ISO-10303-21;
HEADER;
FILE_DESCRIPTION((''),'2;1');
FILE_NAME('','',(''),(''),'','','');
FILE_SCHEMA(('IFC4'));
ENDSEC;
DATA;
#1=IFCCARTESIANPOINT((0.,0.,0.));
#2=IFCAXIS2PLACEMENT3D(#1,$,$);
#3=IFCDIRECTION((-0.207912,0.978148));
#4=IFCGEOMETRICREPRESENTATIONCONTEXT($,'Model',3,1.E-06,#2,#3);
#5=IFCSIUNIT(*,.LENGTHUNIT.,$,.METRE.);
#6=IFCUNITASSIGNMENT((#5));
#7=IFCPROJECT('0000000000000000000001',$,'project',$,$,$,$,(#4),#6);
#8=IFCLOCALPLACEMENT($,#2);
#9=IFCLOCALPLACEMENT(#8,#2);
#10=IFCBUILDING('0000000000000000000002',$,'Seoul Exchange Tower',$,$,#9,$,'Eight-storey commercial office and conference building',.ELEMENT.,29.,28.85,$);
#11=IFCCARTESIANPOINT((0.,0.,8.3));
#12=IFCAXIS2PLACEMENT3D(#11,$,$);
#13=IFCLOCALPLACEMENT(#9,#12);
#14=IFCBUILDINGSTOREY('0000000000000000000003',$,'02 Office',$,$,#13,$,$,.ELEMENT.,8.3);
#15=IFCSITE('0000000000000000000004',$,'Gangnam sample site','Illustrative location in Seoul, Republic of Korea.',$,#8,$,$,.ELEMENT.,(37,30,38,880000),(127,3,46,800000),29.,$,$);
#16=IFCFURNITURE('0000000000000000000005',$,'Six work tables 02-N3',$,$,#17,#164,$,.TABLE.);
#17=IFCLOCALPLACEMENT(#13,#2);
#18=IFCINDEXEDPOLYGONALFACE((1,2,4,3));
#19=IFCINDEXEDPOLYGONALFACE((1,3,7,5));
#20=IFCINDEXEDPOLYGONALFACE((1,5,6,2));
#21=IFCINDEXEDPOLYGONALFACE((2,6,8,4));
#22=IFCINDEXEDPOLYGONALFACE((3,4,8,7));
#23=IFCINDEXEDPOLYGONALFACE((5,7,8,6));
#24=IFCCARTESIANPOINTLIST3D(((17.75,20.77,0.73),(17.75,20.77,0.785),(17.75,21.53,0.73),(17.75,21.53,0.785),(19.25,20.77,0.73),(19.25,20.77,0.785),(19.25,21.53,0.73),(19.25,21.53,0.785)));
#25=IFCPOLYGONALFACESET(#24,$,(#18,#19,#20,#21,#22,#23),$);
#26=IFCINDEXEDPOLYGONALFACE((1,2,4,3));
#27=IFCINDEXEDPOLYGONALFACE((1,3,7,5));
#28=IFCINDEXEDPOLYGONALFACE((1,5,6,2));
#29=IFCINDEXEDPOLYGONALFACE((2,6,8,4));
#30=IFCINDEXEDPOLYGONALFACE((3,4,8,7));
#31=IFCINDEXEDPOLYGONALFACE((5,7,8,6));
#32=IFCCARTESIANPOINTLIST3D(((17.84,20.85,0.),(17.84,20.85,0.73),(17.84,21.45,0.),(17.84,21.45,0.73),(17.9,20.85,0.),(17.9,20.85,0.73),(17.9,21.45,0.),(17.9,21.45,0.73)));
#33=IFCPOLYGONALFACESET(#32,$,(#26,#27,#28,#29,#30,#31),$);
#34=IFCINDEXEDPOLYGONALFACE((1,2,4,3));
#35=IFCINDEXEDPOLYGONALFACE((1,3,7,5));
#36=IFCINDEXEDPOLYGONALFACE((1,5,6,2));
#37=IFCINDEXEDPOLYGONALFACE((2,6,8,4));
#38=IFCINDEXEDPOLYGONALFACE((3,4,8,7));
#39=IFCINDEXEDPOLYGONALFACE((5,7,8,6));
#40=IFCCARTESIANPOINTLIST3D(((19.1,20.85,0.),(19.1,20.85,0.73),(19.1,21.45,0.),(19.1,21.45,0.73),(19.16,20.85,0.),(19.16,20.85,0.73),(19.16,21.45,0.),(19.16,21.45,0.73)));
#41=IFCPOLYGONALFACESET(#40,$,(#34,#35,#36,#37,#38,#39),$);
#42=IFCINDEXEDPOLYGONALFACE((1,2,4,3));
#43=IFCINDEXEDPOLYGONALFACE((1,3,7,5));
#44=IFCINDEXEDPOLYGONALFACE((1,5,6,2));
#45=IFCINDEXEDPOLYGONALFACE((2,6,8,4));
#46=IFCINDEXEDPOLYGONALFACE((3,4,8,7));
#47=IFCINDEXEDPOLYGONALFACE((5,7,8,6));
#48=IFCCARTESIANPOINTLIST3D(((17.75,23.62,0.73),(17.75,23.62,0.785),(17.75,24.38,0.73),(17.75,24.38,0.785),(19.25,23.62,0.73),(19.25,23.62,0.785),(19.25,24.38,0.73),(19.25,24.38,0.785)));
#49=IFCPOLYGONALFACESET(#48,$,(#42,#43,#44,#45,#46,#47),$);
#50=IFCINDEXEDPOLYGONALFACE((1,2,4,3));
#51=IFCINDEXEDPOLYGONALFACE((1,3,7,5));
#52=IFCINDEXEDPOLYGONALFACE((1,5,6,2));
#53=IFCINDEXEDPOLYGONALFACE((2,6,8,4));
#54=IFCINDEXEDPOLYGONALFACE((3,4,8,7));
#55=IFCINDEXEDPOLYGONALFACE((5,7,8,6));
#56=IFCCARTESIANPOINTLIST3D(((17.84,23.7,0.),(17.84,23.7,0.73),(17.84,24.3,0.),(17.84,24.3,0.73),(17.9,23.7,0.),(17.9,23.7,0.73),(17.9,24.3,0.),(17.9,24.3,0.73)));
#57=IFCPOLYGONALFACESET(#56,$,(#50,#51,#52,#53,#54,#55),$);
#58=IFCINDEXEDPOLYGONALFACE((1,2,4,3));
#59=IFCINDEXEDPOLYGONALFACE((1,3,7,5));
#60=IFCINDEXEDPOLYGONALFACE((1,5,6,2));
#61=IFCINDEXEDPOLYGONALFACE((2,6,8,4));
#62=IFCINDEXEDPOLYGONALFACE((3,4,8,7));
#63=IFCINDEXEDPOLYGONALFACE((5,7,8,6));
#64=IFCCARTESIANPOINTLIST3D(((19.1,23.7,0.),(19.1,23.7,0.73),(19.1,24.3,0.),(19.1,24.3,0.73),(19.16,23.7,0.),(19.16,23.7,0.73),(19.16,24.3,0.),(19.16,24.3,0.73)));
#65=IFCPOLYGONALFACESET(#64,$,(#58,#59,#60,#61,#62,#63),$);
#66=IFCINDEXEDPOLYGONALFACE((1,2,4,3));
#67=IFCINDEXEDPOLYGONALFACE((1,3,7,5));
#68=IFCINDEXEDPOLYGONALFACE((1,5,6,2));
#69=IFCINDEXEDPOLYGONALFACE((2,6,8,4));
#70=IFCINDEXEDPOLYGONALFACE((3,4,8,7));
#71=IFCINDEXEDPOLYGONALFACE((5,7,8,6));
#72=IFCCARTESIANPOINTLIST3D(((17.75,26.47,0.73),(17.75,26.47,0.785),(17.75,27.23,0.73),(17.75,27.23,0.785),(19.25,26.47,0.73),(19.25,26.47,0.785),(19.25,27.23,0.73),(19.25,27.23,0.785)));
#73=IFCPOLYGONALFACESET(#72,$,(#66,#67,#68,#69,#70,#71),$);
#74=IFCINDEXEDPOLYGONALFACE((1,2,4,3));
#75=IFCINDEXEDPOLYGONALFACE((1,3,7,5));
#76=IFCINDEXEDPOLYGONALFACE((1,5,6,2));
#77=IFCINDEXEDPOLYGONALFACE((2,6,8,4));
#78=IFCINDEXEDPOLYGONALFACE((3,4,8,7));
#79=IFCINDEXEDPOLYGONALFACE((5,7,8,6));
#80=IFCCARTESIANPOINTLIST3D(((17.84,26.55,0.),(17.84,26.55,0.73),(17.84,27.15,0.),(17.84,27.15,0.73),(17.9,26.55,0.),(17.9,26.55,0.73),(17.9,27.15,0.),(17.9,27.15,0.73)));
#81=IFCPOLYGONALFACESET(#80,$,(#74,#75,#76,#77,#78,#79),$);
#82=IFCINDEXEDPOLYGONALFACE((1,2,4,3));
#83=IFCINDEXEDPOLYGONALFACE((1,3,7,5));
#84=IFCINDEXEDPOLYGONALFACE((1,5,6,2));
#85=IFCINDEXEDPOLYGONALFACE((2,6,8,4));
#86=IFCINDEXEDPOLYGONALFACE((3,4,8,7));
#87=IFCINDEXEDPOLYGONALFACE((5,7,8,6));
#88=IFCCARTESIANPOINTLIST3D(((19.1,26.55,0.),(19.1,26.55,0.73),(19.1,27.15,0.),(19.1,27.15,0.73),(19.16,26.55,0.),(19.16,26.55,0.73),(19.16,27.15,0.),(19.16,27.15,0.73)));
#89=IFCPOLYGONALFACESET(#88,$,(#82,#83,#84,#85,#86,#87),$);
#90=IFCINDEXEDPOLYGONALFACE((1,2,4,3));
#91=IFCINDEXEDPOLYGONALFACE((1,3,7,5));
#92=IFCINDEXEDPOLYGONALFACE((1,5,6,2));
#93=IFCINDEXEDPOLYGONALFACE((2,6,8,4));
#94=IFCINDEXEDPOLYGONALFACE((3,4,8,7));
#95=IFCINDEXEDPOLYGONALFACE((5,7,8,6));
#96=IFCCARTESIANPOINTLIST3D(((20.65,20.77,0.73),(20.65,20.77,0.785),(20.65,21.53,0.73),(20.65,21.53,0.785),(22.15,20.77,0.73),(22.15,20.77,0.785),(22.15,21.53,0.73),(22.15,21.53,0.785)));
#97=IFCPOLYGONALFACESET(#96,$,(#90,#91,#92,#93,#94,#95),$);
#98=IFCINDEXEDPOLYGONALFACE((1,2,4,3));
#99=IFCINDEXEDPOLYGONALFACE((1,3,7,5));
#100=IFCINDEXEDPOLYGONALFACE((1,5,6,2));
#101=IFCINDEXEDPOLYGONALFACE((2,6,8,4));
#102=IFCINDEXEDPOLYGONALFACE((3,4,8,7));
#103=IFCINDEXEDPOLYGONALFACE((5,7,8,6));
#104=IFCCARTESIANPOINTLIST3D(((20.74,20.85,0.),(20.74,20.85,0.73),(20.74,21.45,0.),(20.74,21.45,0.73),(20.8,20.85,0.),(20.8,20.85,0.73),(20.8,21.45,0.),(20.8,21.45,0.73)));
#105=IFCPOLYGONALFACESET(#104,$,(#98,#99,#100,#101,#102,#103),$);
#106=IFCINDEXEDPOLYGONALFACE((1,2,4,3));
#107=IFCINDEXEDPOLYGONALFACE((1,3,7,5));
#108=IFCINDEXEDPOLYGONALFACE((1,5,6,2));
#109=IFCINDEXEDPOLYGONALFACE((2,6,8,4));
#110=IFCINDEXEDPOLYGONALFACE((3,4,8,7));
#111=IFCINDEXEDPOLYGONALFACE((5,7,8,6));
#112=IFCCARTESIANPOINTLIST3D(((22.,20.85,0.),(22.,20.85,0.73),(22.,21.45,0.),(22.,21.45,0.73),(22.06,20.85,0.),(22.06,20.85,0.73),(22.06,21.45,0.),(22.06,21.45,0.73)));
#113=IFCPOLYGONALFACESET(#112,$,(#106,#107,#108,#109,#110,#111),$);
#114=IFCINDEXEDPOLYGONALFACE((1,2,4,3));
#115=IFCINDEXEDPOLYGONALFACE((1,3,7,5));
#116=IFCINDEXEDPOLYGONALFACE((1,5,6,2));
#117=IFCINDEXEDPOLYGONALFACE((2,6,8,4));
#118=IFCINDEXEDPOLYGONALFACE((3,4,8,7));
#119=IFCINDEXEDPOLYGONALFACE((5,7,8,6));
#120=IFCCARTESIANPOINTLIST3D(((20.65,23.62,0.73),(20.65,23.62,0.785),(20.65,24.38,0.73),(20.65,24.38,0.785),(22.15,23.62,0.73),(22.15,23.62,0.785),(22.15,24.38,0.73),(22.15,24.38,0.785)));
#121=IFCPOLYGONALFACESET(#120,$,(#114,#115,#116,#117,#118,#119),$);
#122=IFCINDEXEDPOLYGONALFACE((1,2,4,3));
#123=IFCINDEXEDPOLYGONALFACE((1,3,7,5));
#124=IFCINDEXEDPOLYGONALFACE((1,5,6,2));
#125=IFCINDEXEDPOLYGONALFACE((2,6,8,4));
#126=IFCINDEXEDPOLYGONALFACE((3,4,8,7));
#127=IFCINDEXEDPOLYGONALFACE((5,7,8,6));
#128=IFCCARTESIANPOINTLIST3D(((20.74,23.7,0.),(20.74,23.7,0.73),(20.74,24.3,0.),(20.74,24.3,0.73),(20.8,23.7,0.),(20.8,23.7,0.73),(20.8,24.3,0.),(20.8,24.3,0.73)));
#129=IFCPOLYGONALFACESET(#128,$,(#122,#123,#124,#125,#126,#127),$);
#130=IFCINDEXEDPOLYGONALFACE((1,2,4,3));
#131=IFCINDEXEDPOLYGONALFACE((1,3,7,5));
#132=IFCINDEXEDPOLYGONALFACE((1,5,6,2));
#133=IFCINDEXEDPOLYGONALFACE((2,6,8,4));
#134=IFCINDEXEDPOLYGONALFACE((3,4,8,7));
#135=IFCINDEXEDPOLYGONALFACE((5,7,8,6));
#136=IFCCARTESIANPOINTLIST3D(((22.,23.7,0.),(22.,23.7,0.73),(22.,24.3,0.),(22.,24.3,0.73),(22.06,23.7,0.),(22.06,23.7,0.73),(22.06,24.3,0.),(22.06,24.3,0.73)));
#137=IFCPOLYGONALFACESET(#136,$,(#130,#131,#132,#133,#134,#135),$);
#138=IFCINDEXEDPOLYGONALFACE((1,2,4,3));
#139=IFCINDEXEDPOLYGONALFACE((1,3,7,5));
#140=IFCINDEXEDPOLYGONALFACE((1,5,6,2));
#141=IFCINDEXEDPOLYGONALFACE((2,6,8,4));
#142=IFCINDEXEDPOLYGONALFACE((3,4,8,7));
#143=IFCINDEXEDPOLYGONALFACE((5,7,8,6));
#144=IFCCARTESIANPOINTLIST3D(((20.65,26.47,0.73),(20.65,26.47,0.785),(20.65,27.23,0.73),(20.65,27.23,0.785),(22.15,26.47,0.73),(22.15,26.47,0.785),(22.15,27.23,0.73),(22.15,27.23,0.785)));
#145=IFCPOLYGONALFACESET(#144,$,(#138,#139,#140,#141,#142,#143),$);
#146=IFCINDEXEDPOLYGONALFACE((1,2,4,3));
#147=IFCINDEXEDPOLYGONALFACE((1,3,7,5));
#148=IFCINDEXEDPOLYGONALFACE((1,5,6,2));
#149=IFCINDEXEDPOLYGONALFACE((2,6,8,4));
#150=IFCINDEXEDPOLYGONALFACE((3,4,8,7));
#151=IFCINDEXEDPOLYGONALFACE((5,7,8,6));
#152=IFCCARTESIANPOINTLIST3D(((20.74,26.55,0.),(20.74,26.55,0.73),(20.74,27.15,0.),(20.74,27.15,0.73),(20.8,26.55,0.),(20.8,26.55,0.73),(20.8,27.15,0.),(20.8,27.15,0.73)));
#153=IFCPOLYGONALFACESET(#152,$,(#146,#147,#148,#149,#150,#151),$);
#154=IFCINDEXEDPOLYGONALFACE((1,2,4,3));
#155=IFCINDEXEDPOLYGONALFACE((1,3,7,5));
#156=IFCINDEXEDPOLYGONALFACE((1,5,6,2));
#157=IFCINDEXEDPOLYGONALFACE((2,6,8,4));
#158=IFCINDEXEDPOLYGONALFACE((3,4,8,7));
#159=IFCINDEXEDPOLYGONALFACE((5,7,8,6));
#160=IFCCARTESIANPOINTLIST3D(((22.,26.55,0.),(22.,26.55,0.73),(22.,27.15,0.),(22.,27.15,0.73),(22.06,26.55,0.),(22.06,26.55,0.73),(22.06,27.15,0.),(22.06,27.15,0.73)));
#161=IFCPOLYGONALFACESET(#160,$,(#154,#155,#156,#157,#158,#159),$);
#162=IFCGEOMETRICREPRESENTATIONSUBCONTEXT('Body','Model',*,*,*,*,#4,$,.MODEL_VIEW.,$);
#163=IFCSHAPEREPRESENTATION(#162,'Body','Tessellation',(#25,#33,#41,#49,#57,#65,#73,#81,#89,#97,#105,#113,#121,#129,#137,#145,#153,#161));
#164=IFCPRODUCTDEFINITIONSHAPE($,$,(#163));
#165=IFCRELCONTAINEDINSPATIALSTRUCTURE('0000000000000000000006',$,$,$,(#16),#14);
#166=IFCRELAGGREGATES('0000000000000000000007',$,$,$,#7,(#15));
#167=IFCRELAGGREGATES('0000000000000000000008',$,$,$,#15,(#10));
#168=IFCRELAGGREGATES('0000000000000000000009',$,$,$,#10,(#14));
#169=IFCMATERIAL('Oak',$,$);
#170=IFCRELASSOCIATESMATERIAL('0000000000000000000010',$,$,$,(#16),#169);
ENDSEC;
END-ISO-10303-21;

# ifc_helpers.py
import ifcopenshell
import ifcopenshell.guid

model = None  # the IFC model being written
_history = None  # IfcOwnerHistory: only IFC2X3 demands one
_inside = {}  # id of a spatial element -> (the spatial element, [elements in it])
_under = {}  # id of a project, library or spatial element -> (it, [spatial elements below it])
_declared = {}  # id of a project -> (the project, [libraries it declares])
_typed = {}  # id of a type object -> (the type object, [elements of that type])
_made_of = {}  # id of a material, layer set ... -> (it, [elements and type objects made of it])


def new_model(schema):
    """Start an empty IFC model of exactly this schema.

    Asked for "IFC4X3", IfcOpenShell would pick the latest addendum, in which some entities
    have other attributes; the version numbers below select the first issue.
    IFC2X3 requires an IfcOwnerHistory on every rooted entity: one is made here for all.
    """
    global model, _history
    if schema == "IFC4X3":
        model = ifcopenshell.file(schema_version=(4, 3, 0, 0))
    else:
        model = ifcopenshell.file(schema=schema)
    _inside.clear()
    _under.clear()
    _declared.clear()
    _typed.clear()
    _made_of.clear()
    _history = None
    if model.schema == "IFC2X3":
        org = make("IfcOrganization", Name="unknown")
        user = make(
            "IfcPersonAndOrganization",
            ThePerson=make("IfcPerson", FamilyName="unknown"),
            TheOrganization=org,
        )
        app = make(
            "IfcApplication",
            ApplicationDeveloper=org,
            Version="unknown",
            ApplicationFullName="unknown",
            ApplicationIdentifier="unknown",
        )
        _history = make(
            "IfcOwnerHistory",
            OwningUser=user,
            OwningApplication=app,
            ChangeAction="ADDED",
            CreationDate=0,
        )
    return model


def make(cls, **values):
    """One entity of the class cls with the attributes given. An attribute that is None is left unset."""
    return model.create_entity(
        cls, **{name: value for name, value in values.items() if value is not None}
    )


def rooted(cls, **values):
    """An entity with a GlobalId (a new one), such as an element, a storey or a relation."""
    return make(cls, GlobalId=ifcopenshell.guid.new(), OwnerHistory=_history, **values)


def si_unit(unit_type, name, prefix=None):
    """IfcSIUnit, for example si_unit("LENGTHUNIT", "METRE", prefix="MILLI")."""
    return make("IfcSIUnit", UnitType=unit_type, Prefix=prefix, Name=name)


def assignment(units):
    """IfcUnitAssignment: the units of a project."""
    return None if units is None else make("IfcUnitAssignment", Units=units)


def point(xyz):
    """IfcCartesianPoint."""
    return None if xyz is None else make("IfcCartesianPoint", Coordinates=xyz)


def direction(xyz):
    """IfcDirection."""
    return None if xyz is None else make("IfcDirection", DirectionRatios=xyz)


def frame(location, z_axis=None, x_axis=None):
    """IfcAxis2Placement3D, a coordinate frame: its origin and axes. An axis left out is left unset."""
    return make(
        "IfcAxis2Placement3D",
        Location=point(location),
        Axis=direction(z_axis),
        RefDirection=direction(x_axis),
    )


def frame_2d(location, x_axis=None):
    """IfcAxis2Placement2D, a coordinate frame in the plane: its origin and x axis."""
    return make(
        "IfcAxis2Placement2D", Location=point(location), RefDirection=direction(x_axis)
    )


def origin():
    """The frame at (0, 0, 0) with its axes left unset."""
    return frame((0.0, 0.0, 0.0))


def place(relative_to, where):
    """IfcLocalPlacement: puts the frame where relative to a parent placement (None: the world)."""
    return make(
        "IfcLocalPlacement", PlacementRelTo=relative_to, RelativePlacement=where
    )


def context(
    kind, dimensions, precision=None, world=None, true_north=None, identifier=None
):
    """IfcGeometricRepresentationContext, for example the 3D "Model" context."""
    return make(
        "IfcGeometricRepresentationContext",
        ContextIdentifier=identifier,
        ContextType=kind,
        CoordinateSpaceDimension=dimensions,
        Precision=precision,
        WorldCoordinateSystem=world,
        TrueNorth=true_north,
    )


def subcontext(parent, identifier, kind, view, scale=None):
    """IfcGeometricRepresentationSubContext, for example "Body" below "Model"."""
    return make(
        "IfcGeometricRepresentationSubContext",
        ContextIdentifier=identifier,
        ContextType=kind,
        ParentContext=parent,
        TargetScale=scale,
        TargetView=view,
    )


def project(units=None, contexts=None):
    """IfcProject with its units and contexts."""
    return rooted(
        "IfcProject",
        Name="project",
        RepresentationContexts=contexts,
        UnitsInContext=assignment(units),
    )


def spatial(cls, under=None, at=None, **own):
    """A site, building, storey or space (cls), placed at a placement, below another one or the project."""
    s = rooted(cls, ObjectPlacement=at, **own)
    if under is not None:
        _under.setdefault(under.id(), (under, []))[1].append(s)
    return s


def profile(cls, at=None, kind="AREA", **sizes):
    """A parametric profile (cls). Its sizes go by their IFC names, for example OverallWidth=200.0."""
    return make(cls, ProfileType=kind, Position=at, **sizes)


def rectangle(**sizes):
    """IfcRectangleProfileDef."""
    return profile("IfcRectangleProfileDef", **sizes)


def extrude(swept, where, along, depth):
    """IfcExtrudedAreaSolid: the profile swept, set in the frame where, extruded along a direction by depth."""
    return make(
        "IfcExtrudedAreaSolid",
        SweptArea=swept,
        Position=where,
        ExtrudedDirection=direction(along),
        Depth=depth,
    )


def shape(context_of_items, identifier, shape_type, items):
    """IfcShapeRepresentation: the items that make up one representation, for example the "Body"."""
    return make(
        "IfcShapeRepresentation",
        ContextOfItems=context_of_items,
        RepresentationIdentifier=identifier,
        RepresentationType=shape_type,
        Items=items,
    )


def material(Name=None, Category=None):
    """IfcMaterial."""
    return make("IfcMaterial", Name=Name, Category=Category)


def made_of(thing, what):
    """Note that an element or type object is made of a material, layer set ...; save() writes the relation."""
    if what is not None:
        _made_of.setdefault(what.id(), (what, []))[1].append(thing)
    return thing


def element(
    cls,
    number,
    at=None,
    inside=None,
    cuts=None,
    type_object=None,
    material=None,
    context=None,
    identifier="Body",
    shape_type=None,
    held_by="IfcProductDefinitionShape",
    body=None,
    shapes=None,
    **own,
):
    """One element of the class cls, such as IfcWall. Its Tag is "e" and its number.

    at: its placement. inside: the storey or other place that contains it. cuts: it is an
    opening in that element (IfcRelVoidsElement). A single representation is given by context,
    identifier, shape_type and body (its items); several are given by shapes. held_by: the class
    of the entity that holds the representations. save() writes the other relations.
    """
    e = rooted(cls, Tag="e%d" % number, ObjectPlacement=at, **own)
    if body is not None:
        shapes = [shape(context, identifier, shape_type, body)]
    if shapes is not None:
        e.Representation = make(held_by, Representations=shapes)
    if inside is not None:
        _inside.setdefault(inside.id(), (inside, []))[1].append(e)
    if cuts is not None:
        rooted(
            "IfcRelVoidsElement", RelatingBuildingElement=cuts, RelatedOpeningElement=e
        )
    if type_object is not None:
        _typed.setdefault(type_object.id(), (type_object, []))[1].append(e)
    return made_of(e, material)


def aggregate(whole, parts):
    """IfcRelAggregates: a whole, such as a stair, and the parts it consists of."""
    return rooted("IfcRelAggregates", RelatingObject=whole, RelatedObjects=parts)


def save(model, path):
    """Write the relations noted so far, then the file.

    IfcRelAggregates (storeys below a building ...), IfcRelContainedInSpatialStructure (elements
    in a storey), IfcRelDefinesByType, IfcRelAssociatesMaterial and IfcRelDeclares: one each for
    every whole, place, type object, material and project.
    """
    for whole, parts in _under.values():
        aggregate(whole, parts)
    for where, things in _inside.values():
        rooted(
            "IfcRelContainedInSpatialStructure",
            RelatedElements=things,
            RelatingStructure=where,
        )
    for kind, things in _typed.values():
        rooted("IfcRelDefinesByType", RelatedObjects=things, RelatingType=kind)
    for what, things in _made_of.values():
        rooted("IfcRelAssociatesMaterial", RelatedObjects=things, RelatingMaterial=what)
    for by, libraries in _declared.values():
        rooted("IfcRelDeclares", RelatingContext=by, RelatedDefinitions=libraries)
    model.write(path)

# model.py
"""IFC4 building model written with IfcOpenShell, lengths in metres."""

from ifc_helpers import new_model, si_unit, direction, frame, frame_2d, origin, place, context, subcontext, project, spatial, rectangle, extrude, material, element, save


model = new_model("IFC4")

# Units and contexts
model_context = context("Model", 3, precision=1e-06, world=origin(), true_north=direction((-0.207912, 0.978148)))
body_context = subcontext(model_context, "Body", "Model", "MODEL_VIEW")
ifc_project = project(units=[si_unit("LENGTHUNIT", "METRE")], contexts=[model_context])

# Site, building, storey
site_placement = place(None, origin())
site = spatial("IfcSite", under=ifc_project, at=site_placement, Name="Gangnam sample site", Description="Illustrative location in Seoul, Republic of Korea.", CompositionType="ELEMENT", RefLatitude=(37, 30, 38, 880000), RefLongitude=(127, 3, 46, 800000), RefElevation=29.0)
building_placement = place(site_placement, origin())
building = spatial("IfcBuilding", under=site, at=building_placement, Name="Seoul Exchange Tower", LongName="Eight-storey commercial office and conference building", CompositionType="ELEMENT", ElevationOfRefHeight=29.0, ElevationOfTerrain=28.85)
storey_placement = place(building_placement, frame((0.0, 0.0, 8.3)))
storey = spatial("IfcBuildingStorey", under=building, at=storey_placement, Name="02 Office", CompositionType="ELEMENT", Elevation=8.3)

# Shared definitions
placement_1 = place(storey_placement, origin())

# Furniture
ifc_material_1 = material(Name="Oak")
element("IfcFurniture", 1, at=placement_1, inside=storey, material=ifc_material_1, Name="Six work tables 02-N3", PredefinedType="TABLE", context=body_context, shape_type="SweptSolid", body=[
    extrude(rectangle(XDim=1.5, YDim=0.76, at=frame_2d((0.75, 0.38))), frame((17.75, 20.77, 0.73)), (0.0, 0.0, 1.0), 0.055),
    extrude(rectangle(XDim=0.06, YDim=0.6, at=frame_2d((0.03, 0.3))), frame((17.84, 20.85, 0.0)), (0.0, 0.0, 1.0), 0.73),
    extrude(rectangle(XDim=0.06, YDim=0.6, at=frame_2d((0.03, 0.3))), frame((19.1, 20.85, 0.0)), (0.0, 0.0, 1.0), 0.73),
    extrude(rectangle(XDim=1.5, YDim=0.76, at=frame_2d((0.75, 0.38))), frame((17.75, 23.62, 0.73)), (0.0, 0.0, 1.0), 0.055),
    extrude(rectangle(XDim=0.06, YDim=0.6, at=frame_2d((0.03, 0.3))), frame((17.84, 23.7, 0.0)), (0.0, 0.0, 1.0), 0.73),
    extrude(rectangle(XDim=0.06, YDim=0.6, at=frame_2d((0.03, 0.3))), frame((19.1, 23.7, 0.0)), (0.0, 0.0, 1.0), 0.73),
    extrude(rectangle(XDim=1.5, YDim=0.76, at=frame_2d((0.75, 0.38))), frame((17.75, 26.47, 0.73)), (0.0, 0.0, 1.0), 0.055),
    extrude(rectangle(XDim=0.06, YDim=0.6, at=frame_2d((0.03, 0.3))), frame((17.84, 26.55, 0.0)), (0.0, 0.0, 1.0), 0.73),
    extrude(rectangle(XDim=0.06, YDim=0.6, at=frame_2d((0.03, 0.3))), frame((19.1, 26.55, 0.0)), (0.0, 0.0, 1.0), 0.73),
    extrude(rectangle(XDim=1.5, YDim=0.76, at=frame_2d((0.75, 0.38))), frame((20.65, 20.77, 0.73)), (0.0, 0.0, 1.0), 0.055),
    extrude(rectangle(XDim=0.06, YDim=0.6, at=frame_2d((0.03, 0.3))), frame((20.74, 20.85, 0.0)), (0.0, 0.0, 1.0), 0.73),
    extrude(rectangle(XDim=0.06, YDim=0.6, at=frame_2d((0.03, 0.3))), frame((22.0, 20.85, 0.0)), (0.0, 0.0, 1.0), 0.73),
    extrude(rectangle(XDim=1.5, YDim=0.76, at=frame_2d((0.75, 0.38))), frame((20.65, 23.62, 0.73)), (0.0, 0.0, 1.0), 0.055),
    extrude(rectangle(XDim=0.06, YDim=0.6, at=frame_2d((0.03, 0.3))), frame((20.74, 23.7, 0.0)), (0.0, 0.0, 1.0), 0.73),
    extrude(rectangle(XDim=0.06, YDim=0.6, at=frame_2d((0.03, 0.3))), frame((22.0, 23.7, 0.0)), (0.0, 0.0, 1.0), 0.73),
    extrude(rectangle(XDim=1.5, YDim=0.76, at=frame_2d((0.75, 0.38))), frame((20.65, 26.47, 0.73)), (0.0, 0.0, 1.0), 0.055),
    extrude(rectangle(XDim=0.06, YDim=0.6, at=frame_2d((0.03, 0.3))), frame((20.74, 26.55, 0.0)), (0.0, 0.0, 1.0), 0.73),
    extrude(rectangle(XDim=0.06, YDim=0.6, at=frame_2d((0.03, 0.3))), frame((22.0, 26.55, 0.0)), (0.0, 0.0, 1.0), 0.73),
])

save(model, "model.ifc")
